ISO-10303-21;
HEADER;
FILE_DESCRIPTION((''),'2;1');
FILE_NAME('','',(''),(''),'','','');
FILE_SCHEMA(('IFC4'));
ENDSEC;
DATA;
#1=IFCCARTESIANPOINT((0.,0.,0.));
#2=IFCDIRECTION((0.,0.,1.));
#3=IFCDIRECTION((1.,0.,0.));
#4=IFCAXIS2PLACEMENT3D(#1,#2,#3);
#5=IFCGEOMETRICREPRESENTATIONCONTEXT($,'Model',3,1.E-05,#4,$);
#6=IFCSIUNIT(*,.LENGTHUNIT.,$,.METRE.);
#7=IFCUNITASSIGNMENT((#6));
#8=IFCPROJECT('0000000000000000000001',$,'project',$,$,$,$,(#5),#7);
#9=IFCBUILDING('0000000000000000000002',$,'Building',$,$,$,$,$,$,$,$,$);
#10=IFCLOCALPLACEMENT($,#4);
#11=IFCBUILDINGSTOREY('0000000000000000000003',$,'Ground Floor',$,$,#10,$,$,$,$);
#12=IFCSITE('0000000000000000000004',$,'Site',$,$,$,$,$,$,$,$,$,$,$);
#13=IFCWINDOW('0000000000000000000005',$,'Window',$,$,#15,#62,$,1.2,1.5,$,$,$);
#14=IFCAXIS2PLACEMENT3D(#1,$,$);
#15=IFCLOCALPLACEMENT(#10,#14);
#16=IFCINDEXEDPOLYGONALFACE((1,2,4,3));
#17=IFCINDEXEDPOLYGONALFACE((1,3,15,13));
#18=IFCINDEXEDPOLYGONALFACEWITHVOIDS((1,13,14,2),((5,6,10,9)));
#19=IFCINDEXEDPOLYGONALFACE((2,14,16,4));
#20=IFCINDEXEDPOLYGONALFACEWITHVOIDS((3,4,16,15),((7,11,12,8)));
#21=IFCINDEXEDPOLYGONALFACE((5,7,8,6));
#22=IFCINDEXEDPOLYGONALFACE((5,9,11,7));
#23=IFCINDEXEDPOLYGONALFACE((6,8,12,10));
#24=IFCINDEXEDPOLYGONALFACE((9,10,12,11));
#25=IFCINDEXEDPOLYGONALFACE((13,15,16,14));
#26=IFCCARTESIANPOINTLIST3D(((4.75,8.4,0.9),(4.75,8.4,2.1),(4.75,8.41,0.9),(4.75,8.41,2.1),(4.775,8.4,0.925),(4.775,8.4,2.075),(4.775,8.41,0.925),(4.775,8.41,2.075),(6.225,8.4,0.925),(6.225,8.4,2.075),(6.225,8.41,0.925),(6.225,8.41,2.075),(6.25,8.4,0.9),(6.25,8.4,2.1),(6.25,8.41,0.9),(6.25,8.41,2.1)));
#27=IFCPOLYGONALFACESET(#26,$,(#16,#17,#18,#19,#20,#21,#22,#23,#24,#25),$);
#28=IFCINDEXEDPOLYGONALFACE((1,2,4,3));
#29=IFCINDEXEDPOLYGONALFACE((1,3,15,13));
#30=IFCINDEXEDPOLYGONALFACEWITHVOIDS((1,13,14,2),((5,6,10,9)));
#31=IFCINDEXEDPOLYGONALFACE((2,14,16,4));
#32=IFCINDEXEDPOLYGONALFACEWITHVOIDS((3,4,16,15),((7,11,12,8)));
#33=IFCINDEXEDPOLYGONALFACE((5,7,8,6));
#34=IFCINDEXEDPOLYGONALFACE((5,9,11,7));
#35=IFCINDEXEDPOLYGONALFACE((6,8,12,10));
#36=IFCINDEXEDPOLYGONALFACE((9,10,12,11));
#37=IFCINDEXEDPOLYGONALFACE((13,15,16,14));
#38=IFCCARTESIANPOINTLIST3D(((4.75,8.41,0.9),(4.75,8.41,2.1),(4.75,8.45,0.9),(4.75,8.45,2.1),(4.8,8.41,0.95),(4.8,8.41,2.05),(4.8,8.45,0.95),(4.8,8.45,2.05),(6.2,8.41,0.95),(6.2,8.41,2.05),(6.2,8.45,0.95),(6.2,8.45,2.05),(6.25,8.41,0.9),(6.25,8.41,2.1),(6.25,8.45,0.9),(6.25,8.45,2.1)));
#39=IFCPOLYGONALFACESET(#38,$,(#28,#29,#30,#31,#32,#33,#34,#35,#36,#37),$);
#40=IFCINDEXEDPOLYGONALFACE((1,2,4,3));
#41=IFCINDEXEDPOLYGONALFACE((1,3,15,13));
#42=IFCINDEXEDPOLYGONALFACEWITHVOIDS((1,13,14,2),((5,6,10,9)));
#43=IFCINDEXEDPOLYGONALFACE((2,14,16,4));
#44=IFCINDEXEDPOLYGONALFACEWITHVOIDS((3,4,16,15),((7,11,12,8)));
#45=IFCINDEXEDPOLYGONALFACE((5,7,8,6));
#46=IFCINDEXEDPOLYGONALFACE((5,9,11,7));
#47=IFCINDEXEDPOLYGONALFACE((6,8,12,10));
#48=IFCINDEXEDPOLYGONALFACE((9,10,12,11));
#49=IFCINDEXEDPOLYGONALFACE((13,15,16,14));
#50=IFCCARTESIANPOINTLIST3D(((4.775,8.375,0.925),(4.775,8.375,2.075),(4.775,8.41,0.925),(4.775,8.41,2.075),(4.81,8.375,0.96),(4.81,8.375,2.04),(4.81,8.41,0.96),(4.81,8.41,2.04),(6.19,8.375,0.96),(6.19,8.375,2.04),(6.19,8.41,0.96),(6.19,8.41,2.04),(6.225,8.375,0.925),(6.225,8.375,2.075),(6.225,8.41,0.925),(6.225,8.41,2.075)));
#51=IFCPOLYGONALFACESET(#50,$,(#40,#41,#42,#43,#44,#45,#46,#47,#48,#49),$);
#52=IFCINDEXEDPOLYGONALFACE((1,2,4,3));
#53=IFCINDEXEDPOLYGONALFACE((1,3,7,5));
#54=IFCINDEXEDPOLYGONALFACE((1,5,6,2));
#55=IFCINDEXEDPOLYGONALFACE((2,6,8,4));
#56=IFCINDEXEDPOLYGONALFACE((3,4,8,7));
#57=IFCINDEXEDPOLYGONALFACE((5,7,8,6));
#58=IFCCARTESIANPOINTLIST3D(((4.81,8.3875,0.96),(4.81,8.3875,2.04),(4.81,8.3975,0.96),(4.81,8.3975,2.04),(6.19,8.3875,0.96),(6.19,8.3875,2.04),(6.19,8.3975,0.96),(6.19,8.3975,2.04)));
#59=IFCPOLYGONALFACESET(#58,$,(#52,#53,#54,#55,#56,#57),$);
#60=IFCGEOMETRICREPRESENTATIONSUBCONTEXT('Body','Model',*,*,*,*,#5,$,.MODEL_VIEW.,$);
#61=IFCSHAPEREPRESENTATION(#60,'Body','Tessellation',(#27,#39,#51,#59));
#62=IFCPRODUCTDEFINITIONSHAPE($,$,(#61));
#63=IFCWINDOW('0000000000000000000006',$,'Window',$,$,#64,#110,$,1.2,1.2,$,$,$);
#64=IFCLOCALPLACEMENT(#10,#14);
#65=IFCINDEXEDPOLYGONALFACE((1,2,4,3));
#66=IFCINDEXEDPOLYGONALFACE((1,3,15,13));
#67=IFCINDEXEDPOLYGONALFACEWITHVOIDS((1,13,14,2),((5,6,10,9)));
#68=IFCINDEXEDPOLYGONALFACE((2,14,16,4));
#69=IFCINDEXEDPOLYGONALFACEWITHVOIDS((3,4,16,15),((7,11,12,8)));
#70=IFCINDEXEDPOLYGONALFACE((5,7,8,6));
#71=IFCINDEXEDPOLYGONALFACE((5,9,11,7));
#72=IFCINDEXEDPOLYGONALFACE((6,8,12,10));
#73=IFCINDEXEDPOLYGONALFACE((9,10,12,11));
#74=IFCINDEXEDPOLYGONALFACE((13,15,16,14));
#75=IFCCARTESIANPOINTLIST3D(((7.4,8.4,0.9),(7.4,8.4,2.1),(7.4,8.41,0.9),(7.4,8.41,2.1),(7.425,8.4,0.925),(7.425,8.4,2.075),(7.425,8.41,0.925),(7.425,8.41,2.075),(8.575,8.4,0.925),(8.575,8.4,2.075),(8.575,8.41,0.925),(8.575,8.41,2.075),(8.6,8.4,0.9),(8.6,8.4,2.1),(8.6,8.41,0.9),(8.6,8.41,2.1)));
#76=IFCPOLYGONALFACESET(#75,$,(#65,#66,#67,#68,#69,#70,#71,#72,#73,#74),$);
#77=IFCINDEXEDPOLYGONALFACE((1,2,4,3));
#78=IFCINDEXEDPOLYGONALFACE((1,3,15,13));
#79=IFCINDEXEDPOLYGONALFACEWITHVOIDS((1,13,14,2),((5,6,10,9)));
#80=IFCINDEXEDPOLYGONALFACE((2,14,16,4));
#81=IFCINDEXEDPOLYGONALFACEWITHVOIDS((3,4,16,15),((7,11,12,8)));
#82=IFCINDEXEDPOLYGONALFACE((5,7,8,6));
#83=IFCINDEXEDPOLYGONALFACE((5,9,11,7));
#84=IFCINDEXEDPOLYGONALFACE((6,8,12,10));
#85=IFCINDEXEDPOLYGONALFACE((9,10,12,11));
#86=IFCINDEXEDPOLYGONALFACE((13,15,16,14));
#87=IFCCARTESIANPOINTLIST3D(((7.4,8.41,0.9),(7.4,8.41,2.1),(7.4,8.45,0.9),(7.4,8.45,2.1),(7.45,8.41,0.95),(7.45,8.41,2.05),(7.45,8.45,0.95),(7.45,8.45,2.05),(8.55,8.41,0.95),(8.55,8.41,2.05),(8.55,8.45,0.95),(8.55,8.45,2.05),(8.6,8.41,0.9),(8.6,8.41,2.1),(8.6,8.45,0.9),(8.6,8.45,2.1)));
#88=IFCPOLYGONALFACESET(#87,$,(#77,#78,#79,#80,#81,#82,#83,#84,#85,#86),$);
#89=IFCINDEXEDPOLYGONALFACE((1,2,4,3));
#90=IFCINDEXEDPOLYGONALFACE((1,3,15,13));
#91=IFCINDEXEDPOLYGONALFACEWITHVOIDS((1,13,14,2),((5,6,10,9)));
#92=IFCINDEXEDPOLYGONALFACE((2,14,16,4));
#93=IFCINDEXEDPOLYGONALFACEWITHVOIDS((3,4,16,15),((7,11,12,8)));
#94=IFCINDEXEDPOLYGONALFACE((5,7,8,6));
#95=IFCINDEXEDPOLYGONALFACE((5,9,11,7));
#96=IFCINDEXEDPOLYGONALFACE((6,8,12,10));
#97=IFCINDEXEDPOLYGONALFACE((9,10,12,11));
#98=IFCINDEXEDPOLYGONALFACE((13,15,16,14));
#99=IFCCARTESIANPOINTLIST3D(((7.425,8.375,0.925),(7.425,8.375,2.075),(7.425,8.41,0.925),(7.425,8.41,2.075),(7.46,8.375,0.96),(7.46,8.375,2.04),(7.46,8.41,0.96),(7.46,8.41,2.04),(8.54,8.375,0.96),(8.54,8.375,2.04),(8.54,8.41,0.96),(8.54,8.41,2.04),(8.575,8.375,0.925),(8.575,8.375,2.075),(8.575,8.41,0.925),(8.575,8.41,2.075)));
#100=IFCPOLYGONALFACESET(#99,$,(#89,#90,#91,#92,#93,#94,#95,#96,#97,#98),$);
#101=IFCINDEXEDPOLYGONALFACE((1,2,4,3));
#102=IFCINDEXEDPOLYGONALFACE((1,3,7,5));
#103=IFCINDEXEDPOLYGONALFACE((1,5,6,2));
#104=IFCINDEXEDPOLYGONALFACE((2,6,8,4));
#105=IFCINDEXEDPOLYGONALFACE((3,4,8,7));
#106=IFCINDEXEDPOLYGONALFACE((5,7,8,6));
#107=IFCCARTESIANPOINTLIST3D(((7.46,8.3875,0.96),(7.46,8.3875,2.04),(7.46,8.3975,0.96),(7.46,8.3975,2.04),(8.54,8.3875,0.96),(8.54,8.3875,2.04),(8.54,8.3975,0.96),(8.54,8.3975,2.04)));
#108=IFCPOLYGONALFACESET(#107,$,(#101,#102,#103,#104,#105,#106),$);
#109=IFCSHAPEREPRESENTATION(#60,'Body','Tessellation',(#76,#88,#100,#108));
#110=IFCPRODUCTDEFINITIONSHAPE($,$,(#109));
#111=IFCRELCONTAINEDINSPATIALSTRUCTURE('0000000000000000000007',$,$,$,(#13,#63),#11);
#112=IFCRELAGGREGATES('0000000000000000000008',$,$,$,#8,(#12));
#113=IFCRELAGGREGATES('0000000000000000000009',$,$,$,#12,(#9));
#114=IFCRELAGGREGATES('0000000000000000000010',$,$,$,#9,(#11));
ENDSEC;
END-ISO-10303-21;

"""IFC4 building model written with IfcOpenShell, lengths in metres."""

from ifc_helpers import new_model, si_unit, frame, origin_with_axes, place, context, subcontext, project, spatial, line, indexed_curve, outline, extrude, element, save


model = new_model("IFC4")

# Units and contexts
model_context = context("Model", 3, precision=1e-05, world=origin_with_axes())
body_context = subcontext(model_context, "Body", "Model", "MODEL_VIEW")
ifc_project = project(units=[si_unit("LENGTHUNIT", "METRE")], contexts=[model_context])

# Site, building, storey
site = spatial("IfcSite", under=ifc_project, Name="Site")
building = spatial("IfcBuilding", under=site, Name="Building")
storey_placement = place(None, origin_with_axes())
storey = spatial("IfcBuildingStorey", under=building, at=storey_placement, Name="Ground Floor")

# Windows
window_1_placement = place(storey_placement, frame((6.25, 8.5, 0.9), z_axis=(0.0, 0.0, 1.0), x_axis=(-1.0, 0.0, 0.0)))
element("IfcWindow", 1, at=window_1_placement, inside=storey, Name="Window", OverallHeight=1.2, OverallWidth=1.5, context=body_context, shape_type="SweptSolid", body=[
    extrude(outline(indexed_curve([(0.0, 0.0), (1.5, 0.0), (1.5, 1.2), (0.0, 1.2)], segments=[line(1, 2, 3, 4, 1)]), holes=[indexed_curve([(0.025, 0.025), (1.475, 0.025), (1.475, 1.175), (0.025, 1.175)], segments=[line(1, 2, 3, 4, 1)])]), frame((0.0, 0.09, 0.0), z_axis=(0.0, -1.0, 0.0), x_axis=(1.0, 0.0, 0.0)), (0.0, 0.0, -1.0), 0.01),
    extrude(outline(indexed_curve([(0.0, 0.0), (1.5, 0.0), (1.5, 1.2), (0.0, 1.2)], segments=[line(1, 2, 3, 4, 1)]), holes=[indexed_curve([(0.05, 0.05), (1.45, 0.05), (1.45, 1.15), (0.05, 1.15)], segments=[line(1, 2, 3, 4, 1)])]), frame((0.0, 0.05, 0.0), z_axis=(0.0, -1.0, 0.0), x_axis=(1.0, 0.0, 0.0)), (0.0, 0.0, -1.0), 0.04),
    extrude(outline(indexed_curve([(0.0, 0.0), (1.45, 0.0), (1.45, 1.15), (0.0, 1.15)], segments=[line(1, 2, 3, 4, 1)]), holes=[indexed_curve([(0.035, 0.035), (1.415, 0.035), (1.415, 1.115), (0.035, 1.115)], segments=[line(1, 2, 3, 4, 1)])]), frame((0.025, 0.09, 0.025), z_axis=(0.0, -1.0, 0.0), x_axis=(1.0, 0.0, 0.0)), (0.0, 0.0, -1.0), 0.035),
    extrude(outline(indexed_curve([(0.035, 0.035), (1.415, 0.035), (1.415, 1.115), (0.035, 1.115)], segments=[line(1, 2, 3, 4, 1)])), frame((0.025, 0.1025, 0.025), z_axis=(0.0, -1.0, 0.0), x_axis=(1.0, 0.0, 0.0)), (0.0, 0.0, -1.0), 0.01),
])
window_2_placement = place(storey_placement, frame((8.6, 8.5, 0.9), z_axis=(0.0, 0.0, 1.0), x_axis=(-1.0, 0.0, 0.0)))
element("IfcWindow", 2, at=window_2_placement, inside=storey, Name="Window", OverallHeight=1.2, OverallWidth=1.2, context=body_context, shape_type="SweptSolid", body=[
    extrude(outline(indexed_curve([(0.0, 0.0), (1.2, 0.0), (1.2, 1.2), (0.0, 1.2)], segments=[line(1, 2, 3, 4, 1)]), holes=[indexed_curve([(0.025, 0.025), (1.175, 0.025), (1.175, 1.175), (0.025, 1.175)], segments=[line(1, 2, 3, 4, 1)])]), frame((0.0, 0.09, 0.0), z_axis=(0.0, -1.0, 0.0), x_axis=(1.0, 0.0, 0.0)), (0.0, 0.0, -1.0), 0.01),
    extrude(outline(indexed_curve([(0.0, 0.0), (1.2, 0.0), (1.2, 1.2), (0.0, 1.2)], segments=[line(1, 2, 3, 4, 1)]), holes=[indexed_curve([(0.05, 0.05), (1.15, 0.05), (1.15, 1.15), (0.05, 1.15)], segments=[line(1, 2, 3, 4, 1)])]), frame((0.0, 0.05, 0.0), z_axis=(0.0, -1.0, 0.0), x_axis=(1.0, 0.0, 0.0)), (0.0, 0.0, -1.0), 0.04),
    extrude(outline(indexed_curve([(0.0, 0.0), (1.15, 0.0), (1.15, 1.15), (0.0, 1.15)], segments=[line(1, 2, 3, 4, 1)]), holes=[indexed_curve([(0.035, 0.035), (1.115, 0.035), (1.115, 1.115), (0.035, 1.115)], segments=[line(1, 2, 3, 4, 1)])]), frame((0.025, 0.09, 0.025), z_axis=(0.0, -1.0, 0.0), x_axis=(1.0, 0.0, 0.0)), (0.0, 0.0, -1.0), 0.035),
    extrude(outline(indexed_curve([(0.035, 0.035), (1.115, 0.035), (1.115, 1.115), (0.035, 1.115)], segments=[line(1, 2, 3, 4, 1)])), frame((0.025, 0.1025, 0.025), z_axis=(0.0, -1.0, 0.0), x_axis=(1.0, 0.0, 0.0)), (0.0, 0.0, -1.0), 0.01),
])

save(model, "model.ifc")
